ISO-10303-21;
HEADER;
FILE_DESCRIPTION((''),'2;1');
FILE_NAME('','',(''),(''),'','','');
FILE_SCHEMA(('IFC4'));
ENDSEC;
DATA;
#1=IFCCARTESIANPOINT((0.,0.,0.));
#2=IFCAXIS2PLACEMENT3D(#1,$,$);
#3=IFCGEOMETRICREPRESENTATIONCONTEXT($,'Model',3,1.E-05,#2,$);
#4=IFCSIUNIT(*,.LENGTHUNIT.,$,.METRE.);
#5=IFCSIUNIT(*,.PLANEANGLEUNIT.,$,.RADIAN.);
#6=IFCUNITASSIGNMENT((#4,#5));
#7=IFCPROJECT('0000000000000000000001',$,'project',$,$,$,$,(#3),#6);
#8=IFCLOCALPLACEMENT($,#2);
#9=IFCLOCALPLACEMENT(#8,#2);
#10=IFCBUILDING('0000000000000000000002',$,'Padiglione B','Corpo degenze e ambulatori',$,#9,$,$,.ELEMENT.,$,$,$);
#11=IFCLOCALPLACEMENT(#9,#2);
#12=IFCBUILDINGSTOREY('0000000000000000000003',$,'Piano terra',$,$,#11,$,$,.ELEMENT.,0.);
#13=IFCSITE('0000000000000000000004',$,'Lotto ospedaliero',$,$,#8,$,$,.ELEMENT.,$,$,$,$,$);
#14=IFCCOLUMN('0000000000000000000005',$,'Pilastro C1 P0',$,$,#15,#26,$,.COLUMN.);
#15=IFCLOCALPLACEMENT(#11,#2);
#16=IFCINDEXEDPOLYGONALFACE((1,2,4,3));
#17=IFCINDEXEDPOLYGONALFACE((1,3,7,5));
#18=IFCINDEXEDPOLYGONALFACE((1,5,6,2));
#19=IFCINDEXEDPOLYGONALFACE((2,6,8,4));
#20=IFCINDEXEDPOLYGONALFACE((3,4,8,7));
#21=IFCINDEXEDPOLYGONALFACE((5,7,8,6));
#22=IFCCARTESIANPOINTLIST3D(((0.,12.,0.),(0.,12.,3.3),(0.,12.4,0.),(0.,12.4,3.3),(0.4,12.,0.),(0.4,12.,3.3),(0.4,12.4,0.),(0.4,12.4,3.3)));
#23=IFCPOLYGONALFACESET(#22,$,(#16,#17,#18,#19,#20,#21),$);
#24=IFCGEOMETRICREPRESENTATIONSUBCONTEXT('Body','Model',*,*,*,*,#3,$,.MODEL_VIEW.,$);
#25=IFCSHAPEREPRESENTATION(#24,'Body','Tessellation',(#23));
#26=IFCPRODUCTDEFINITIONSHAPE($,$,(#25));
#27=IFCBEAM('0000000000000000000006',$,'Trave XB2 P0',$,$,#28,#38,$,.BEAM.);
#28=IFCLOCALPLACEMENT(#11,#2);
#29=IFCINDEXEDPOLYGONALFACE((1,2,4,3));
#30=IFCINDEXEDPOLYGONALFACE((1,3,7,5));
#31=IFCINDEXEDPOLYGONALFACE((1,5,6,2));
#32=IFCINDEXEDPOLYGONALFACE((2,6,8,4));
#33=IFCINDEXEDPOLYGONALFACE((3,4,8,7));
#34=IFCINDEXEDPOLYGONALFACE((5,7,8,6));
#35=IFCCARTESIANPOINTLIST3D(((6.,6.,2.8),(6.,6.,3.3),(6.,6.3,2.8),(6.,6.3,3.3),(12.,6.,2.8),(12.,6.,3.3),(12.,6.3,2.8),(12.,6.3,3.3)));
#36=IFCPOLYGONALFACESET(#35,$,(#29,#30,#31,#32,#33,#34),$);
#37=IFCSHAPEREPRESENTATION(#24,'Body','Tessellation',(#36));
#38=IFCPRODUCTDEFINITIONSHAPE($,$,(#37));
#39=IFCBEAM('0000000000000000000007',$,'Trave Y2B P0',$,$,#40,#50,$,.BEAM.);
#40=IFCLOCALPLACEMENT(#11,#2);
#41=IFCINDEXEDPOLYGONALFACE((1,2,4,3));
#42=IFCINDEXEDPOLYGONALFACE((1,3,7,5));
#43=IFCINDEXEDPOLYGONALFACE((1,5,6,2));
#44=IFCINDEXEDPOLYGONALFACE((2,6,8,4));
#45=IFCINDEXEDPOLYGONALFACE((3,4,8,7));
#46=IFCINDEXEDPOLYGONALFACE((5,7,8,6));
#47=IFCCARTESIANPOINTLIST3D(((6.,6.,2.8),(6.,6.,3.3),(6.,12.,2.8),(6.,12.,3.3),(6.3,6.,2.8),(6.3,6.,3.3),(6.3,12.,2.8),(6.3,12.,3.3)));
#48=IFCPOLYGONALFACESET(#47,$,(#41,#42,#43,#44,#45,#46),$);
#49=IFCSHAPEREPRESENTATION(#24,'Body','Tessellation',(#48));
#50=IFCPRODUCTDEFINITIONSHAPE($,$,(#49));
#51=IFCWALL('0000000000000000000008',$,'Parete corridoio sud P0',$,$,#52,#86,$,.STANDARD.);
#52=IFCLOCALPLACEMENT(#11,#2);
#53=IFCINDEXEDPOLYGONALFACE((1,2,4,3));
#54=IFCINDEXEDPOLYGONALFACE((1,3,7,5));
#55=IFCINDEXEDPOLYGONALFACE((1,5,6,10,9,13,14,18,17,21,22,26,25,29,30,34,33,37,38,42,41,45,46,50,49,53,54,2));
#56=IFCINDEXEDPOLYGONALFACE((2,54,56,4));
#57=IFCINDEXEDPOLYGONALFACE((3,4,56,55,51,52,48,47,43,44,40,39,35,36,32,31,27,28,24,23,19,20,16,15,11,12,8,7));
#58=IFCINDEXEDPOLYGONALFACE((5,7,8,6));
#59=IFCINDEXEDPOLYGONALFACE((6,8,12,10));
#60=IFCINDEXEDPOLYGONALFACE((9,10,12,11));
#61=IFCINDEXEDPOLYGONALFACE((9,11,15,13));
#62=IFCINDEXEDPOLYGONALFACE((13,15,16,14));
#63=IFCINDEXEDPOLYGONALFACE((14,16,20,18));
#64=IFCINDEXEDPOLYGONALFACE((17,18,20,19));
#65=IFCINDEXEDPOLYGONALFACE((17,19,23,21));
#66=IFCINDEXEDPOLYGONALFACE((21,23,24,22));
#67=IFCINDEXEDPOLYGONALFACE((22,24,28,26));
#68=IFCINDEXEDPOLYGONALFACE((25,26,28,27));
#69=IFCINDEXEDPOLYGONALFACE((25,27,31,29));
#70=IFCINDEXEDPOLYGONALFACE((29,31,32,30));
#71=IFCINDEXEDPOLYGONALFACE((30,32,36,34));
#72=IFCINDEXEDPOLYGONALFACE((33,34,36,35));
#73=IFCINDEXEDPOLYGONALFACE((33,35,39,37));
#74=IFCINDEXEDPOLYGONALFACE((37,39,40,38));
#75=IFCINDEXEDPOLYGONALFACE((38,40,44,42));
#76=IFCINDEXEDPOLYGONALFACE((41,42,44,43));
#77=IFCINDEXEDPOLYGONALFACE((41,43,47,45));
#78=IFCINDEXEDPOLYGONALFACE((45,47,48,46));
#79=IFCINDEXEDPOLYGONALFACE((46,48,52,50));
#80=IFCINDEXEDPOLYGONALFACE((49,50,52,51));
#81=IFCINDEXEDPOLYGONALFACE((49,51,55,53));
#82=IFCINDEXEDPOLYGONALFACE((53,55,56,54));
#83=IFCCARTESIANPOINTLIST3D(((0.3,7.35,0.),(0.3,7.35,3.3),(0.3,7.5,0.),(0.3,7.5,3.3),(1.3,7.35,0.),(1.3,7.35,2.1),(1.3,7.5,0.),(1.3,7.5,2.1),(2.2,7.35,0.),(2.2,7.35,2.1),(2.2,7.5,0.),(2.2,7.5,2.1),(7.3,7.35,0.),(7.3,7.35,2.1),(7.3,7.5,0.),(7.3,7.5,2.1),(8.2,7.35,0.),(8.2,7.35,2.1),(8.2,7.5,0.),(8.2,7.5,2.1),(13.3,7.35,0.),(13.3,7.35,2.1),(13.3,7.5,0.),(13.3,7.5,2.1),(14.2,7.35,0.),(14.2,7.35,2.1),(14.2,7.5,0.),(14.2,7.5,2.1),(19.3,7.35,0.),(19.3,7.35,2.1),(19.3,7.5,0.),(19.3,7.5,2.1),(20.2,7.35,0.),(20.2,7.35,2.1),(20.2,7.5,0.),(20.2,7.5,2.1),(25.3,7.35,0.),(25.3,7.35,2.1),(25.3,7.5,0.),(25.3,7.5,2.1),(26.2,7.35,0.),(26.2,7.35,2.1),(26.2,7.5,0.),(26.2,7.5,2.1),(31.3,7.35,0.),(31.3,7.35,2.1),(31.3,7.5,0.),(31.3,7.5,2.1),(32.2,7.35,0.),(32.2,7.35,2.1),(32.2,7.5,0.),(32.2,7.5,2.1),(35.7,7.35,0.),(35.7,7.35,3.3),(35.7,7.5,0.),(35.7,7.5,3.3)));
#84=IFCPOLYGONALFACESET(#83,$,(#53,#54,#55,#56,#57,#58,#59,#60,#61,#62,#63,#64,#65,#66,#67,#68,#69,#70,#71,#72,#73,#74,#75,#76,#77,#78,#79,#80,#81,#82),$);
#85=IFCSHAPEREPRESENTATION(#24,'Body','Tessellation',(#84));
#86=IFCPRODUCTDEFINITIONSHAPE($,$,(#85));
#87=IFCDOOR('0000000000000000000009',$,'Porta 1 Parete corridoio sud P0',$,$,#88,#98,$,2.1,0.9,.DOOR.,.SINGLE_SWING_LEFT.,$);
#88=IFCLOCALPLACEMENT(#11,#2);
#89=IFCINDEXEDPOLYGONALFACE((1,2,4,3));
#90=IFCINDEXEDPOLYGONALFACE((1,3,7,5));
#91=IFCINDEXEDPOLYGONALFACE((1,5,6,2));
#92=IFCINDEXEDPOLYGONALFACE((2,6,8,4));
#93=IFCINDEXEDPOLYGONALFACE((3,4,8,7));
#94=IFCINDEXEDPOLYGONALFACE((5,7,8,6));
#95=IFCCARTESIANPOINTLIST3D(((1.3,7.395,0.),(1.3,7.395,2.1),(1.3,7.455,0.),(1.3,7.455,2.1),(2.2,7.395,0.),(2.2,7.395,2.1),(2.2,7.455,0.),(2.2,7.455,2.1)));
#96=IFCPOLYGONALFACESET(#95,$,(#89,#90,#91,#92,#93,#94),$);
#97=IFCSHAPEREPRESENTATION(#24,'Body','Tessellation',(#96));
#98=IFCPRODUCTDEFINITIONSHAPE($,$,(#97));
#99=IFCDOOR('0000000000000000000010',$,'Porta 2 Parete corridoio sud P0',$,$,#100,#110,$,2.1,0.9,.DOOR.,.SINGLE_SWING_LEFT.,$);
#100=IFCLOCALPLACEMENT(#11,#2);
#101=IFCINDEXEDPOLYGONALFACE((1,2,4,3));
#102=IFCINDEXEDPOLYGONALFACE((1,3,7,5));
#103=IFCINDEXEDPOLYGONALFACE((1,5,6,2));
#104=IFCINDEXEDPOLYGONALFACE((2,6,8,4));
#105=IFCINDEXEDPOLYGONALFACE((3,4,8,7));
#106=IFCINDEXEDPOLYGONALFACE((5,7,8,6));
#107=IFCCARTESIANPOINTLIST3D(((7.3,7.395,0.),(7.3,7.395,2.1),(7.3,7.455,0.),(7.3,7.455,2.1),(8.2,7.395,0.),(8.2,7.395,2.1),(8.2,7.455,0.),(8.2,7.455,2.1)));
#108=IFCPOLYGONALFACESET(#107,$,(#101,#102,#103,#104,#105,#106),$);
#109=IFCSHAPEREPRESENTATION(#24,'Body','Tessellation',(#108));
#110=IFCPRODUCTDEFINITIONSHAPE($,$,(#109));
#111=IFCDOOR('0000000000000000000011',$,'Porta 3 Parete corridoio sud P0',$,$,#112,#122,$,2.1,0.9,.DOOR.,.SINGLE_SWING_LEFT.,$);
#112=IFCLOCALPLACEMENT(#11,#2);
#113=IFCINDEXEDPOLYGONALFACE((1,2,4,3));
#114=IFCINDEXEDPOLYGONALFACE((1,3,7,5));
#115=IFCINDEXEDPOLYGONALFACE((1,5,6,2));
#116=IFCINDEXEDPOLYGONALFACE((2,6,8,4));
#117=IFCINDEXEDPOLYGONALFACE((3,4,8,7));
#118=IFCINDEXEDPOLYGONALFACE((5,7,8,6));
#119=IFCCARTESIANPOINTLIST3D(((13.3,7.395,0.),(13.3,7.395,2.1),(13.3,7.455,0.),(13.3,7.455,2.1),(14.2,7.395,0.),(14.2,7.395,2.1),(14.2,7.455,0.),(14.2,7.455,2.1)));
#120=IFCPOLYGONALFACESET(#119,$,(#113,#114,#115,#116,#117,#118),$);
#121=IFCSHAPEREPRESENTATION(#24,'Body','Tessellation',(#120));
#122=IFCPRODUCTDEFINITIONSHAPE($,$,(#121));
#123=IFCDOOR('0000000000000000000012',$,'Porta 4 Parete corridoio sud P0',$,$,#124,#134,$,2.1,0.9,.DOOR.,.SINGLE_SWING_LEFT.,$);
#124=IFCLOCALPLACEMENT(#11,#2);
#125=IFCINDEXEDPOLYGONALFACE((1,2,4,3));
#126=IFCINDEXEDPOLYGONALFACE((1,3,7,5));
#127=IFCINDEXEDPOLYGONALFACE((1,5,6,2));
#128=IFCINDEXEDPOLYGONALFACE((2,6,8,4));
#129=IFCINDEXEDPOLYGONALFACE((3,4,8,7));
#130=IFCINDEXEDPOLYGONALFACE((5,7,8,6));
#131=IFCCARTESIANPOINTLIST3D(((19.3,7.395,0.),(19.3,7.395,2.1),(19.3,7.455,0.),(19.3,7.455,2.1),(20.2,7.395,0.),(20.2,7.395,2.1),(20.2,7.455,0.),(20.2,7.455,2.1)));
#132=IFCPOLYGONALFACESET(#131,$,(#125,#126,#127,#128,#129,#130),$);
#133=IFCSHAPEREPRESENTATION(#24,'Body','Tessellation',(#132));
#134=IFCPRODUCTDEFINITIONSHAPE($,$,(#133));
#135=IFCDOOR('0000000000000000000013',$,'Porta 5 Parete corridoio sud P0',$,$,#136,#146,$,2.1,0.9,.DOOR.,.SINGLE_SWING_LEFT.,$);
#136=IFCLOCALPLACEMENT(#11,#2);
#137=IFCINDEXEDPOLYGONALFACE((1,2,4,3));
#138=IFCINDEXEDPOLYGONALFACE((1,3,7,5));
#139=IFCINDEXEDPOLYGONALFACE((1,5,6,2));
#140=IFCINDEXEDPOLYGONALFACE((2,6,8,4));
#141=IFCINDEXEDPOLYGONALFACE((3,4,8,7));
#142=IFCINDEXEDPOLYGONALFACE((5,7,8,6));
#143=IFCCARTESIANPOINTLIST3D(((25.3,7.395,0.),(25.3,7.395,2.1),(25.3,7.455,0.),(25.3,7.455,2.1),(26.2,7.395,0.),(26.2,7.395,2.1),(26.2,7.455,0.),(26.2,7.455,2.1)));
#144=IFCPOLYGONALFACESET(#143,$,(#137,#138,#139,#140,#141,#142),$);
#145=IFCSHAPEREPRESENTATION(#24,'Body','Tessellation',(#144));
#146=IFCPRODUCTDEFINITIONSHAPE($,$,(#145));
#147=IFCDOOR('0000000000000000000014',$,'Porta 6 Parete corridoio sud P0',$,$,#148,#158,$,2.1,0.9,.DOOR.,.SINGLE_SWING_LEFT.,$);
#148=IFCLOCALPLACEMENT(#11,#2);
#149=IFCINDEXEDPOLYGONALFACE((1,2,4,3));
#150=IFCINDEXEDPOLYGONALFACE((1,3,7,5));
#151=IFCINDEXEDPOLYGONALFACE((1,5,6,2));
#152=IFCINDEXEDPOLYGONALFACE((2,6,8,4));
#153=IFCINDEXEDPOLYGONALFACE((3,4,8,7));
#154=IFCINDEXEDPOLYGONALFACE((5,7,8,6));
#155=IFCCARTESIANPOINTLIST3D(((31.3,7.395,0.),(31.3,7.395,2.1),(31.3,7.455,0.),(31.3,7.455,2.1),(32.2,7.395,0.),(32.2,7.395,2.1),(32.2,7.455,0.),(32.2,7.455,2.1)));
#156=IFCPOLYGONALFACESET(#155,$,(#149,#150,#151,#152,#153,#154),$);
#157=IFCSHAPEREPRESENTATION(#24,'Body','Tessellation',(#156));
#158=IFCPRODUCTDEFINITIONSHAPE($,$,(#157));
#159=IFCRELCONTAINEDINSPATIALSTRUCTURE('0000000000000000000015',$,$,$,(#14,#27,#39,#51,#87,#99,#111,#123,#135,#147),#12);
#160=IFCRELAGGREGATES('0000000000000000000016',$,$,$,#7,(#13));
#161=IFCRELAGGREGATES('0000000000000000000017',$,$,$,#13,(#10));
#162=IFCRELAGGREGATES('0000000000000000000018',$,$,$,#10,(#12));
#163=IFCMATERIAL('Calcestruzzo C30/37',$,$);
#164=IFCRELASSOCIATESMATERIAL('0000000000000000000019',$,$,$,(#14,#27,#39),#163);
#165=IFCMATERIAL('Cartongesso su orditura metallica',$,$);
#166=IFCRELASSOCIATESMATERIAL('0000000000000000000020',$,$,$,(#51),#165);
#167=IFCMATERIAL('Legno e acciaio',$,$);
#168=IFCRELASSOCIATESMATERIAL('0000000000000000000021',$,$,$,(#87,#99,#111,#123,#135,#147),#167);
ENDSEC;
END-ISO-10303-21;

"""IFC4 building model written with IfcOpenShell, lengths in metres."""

from ifc_helpers import new_model, si_unit, frame, frame_2d, origin, place, context, subcontext, project, spatial, rectangle, extrude, material, element, fill, save


model = new_model("IFC4")

# Units and contexts
model_context = context("Model", 3, precision=1e-05, world=origin())
body_context = subcontext(model_context, "Body", "Model", "MODEL_VIEW")
ifc_project = project(units=[si_unit("LENGTHUNIT", "METRE"), si_unit("PLANEANGLEUNIT", "RADIAN")], contexts=[model_context])

# Site, building, storey
site_placement = place(None, origin())
site = spatial("IfcSite", under=ifc_project, at=site_placement, Name="Lotto ospedaliero", CompositionType="ELEMENT")
building_placement = place(site_placement, origin())
building = spatial("IfcBuilding", under=site, at=building_placement, Name="Padiglione B", Description="Corpo degenze e ambulatori", CompositionType="ELEMENT")
storey_placement = place(building_placement, origin())
storey = spatial("IfcBuildingStorey", under=building, at=storey_placement, Name="Piano terra", CompositionType="ELEMENT", Elevation=0.0)

# Column
ifc_material_1 = material(Name="Calcestruzzo C30/37")
column_placement = place(storey_placement, frame((0.0, 12.0, 0.0)))
element("IfcColumn", 1, at=column_placement, inside=storey, material=ifc_material_1, Name="Pilastro C1 P0", PredefinedType="COLUMN", context=body_context, shape_type="SweptSolid", body=[
    extrude(rectangle(XDim=0.4, YDim=0.4, at=frame_2d((0.2, 0.2))), origin(), (0.0, 0.0, 1.0), 3.3),
])

# Beams
beam_1_placement = place(storey_placement, frame((6.0, 6.0, 2.8)))
element("IfcBeam", 2, at=beam_1_placement, inside=storey, material=ifc_material_1, Name="Trave XB2 P0", PredefinedType="BEAM", context=body_context, shape_type="SweptSolid", body=[
    extrude(rectangle(XDim=6.0, YDim=0.3, at=frame_2d((3.0, 0.15))), origin(), (0.0, 0.0, 1.0), 0.5),
])
beam_2_placement = place(storey_placement, frame((6.0, 6.0, 2.8)))
element("IfcBeam", 3, at=beam_2_placement, inside=storey, material=ifc_material_1, Name="Trave Y2B P0", PredefinedType="BEAM", context=body_context, shape_type="SweptSolid", body=[
    extrude(rectangle(XDim=0.3, YDim=6.0, at=frame_2d((0.15, 3.0))), origin(), (0.0, 0.0, 1.0), 0.5),
])

# Wall, openings, doors
ifc_material_2 = material(Name="Cartongesso su orditura metallica")
wall_1_placement = place(storey_placement, frame((0.3, 7.35, 0.0)))
wall_1 = element("IfcWall", 4, at=wall_1_placement, inside=storey, material=ifc_material_2, Name="Parete corridoio sud P0", PredefinedType="STANDARD", context=body_context, shape_type="SweptSolid", body=[
    extrude(rectangle(XDim=35.4, YDim=0.15, at=frame_2d((17.7, 0.075))), origin(), (0.0, 0.0, 1.0), 3.3),
])
opening_1_placement = place(wall_1_placement, frame((1.0, -0.1, 0.0)))
opening_1 = element("IfcOpeningElement", 5, at=opening_1_placement, cuts=wall_1, PredefinedType="OPENING", context=body_context, shape_type="SweptSolid", body=[
    extrude(rectangle(XDim=0.9, YDim=0.35, at=frame_2d((0.45, 0.175))), origin(), (0.0, 0.0, 1.0), 2.1),
])
opening_2_placement = place(wall_1_placement, frame((7.0, -0.1, 0.0)))
opening_2 = element("IfcOpeningElement", 6, at=opening_2_placement, cuts=wall_1, PredefinedType="OPENING", context=body_context, shape_type="SweptSolid", body=[
    extrude(rectangle(XDim=0.9, YDim=0.35, at=frame_2d((0.45, 0.175))), origin(), (0.0, 0.0, 1.0), 2.1),
])
opening_3_placement = place(wall_1_placement, frame((13.0, -0.1, 0.0)))
opening_3 = element("IfcOpeningElement", 7, at=opening_3_placement, cuts=wall_1, PredefinedType="OPENING", context=body_context, shape_type="SweptSolid", body=[
    extrude(rectangle(XDim=0.9, YDim=0.35, at=frame_2d((0.45, 0.175))), origin(), (0.0, 0.0, 1.0), 2.1),
])
opening_4_placement = place(wall_1_placement, frame((19.0, -0.1, 0.0)))
opening_4 = element("IfcOpeningElement", 8, at=opening_4_placement, cuts=wall_1, PredefinedType="OPENING", context=body_context, shape_type="SweptSolid", body=[
    extrude(rectangle(XDim=0.9, YDim=0.35, at=frame_2d((0.45, 0.175))), origin(), (0.0, 0.0, 1.0), 2.1),
])
opening_5_placement = place(wall_1_placement, frame((25.0, -0.1, 0.0)))
opening_5 = element("IfcOpeningElement", 9, at=opening_5_placement, cuts=wall_1, PredefinedType="OPENING", context=body_context, shape_type="SweptSolid", body=[
    extrude(rectangle(XDim=0.9, YDim=0.35, at=frame_2d((0.45, 0.175))), origin(), (0.0, 0.0, 1.0), 2.1),
])
opening_6_placement = place(wall_1_placement, frame((31.0, -0.1, 0.0)))
opening_6 = element("IfcOpeningElement", 10, at=opening_6_placement, cuts=wall_1, PredefinedType="OPENING", context=body_context, shape_type="SweptSolid", body=[
    extrude(rectangle(XDim=0.9, YDim=0.35, at=frame_2d((0.45, 0.175))), origin(), (0.0, 0.0, 1.0), 2.1),
])
ifc_material_3 = material(Name="Legno e acciaio")
door_1_placement = place(wall_1_placement, frame((1.0, 0.045, 0.0)))
door_1 = element("IfcDoor", 11, at=door_1_placement, inside=storey, material=ifc_material_3, Name="Porta 1 Parete corridoio sud P0", OperationType="SINGLE_SWING_LEFT", OverallHeight=2.1, OverallWidth=0.9, PredefinedType="DOOR", context=body_context, shape_type="SweptSolid", body=[
    extrude(rectangle(XDim=0.9, YDim=0.06, at=frame_2d((0.45, 0.03))), origin(), (0.0, 0.0, 1.0), 2.1),
])
fill(opening_1, door_1)
door_2_placement = place(wall_1_placement, frame((7.0, 0.045, 0.0)))
door_2 = element("IfcDoor", 12, at=door_2_placement, inside=storey, material=ifc_material_3, Name="Porta 2 Parete corridoio sud P0", OperationType="SINGLE_SWING_LEFT", OverallHeight=2.1, OverallWidth=0.9, PredefinedType="DOOR", context=body_context, shape_type="SweptSolid", body=[
    extrude(rectangle(XDim=0.9, YDim=0.06, at=frame_2d((0.45, 0.03))), origin(), (0.0, 0.0, 1.0), 2.1),
])
fill(opening_2, door_2)
door_3_placement = place(wall_1_placement, frame((13.0, 0.045, 0.0)))
door_3 = element("IfcDoor", 13, at=door_3_placement, inside=storey, material=ifc_material_3, Name="Porta 3 Parete corridoio sud P0", OperationType="SINGLE_SWING_LEFT", OverallHeight=2.1, OverallWidth=0.9, PredefinedType="DOOR", context=body_context, shape_type="SweptSolid", body=[
    extrude(rectangle(XDim=0.9, YDim=0.06, at=frame_2d((0.45, 0.03))), origin(), (0.0, 0.0, 1.0), 2.1),
])
fill(opening_3, door_3)
door_4_placement = place(wall_1_placement, frame((19.0, 0.045, 0.0)))
door_4 = element("IfcDoor", 14, at=door_4_placement, inside=storey, material=ifc_material_3, Name="Porta 4 Parete corridoio sud P0", OperationType="SINGLE_SWING_LEFT", OverallHeight=2.1, OverallWidth=0.9, PredefinedType="DOOR", context=body_context, shape_type="SweptSolid", body=[
    extrude(rectangle(XDim=0.9, YDim=0.06, at=frame_2d((0.45, 0.03))), origin(), (0.0, 0.0, 1.0), 2.1),
])
fill(opening_4, door_4)
door_5_placement = place(wall_1_placement, frame((25.0, 0.045, 0.0)))
door_5 = element("IfcDoor", 15, at=door_5_placement, inside=storey, material=ifc_material_3, Name="Porta 5 Parete corridoio sud P0", OperationType="SINGLE_SWING_LEFT", OverallHeight=2.1, OverallWidth=0.9, PredefinedType="DOOR", context=body_context, shape_type="SweptSolid", body=[
    extrude(rectangle(XDim=0.9, YDim=0.06, at=frame_2d((0.45, 0.03))), origin(), (0.0, 0.0, 1.0), 2.1),
])
fill(opening_5, door_5)
door_6_placement = place(wall_1_placement, frame((31.0, 0.045, 0.0)))
door_6 = element("IfcDoor", 16, at=door_6_placement, inside=storey, material=ifc_material_3, Name="Porta 6 Parete corridoio sud P0", OperationType="SINGLE_SWING_LEFT", OverallHeight=2.1, OverallWidth=0.9, PredefinedType="DOOR", context=body_context, shape_type="SweptSolid", body=[
    extrude(rectangle(XDim=0.9, YDim=0.06, at=frame_2d((0.45, 0.03))), origin(), (0.0, 0.0, 1.0), 2.1),
])
fill(opening_6, door_6)

save(model, "model.ifc")
